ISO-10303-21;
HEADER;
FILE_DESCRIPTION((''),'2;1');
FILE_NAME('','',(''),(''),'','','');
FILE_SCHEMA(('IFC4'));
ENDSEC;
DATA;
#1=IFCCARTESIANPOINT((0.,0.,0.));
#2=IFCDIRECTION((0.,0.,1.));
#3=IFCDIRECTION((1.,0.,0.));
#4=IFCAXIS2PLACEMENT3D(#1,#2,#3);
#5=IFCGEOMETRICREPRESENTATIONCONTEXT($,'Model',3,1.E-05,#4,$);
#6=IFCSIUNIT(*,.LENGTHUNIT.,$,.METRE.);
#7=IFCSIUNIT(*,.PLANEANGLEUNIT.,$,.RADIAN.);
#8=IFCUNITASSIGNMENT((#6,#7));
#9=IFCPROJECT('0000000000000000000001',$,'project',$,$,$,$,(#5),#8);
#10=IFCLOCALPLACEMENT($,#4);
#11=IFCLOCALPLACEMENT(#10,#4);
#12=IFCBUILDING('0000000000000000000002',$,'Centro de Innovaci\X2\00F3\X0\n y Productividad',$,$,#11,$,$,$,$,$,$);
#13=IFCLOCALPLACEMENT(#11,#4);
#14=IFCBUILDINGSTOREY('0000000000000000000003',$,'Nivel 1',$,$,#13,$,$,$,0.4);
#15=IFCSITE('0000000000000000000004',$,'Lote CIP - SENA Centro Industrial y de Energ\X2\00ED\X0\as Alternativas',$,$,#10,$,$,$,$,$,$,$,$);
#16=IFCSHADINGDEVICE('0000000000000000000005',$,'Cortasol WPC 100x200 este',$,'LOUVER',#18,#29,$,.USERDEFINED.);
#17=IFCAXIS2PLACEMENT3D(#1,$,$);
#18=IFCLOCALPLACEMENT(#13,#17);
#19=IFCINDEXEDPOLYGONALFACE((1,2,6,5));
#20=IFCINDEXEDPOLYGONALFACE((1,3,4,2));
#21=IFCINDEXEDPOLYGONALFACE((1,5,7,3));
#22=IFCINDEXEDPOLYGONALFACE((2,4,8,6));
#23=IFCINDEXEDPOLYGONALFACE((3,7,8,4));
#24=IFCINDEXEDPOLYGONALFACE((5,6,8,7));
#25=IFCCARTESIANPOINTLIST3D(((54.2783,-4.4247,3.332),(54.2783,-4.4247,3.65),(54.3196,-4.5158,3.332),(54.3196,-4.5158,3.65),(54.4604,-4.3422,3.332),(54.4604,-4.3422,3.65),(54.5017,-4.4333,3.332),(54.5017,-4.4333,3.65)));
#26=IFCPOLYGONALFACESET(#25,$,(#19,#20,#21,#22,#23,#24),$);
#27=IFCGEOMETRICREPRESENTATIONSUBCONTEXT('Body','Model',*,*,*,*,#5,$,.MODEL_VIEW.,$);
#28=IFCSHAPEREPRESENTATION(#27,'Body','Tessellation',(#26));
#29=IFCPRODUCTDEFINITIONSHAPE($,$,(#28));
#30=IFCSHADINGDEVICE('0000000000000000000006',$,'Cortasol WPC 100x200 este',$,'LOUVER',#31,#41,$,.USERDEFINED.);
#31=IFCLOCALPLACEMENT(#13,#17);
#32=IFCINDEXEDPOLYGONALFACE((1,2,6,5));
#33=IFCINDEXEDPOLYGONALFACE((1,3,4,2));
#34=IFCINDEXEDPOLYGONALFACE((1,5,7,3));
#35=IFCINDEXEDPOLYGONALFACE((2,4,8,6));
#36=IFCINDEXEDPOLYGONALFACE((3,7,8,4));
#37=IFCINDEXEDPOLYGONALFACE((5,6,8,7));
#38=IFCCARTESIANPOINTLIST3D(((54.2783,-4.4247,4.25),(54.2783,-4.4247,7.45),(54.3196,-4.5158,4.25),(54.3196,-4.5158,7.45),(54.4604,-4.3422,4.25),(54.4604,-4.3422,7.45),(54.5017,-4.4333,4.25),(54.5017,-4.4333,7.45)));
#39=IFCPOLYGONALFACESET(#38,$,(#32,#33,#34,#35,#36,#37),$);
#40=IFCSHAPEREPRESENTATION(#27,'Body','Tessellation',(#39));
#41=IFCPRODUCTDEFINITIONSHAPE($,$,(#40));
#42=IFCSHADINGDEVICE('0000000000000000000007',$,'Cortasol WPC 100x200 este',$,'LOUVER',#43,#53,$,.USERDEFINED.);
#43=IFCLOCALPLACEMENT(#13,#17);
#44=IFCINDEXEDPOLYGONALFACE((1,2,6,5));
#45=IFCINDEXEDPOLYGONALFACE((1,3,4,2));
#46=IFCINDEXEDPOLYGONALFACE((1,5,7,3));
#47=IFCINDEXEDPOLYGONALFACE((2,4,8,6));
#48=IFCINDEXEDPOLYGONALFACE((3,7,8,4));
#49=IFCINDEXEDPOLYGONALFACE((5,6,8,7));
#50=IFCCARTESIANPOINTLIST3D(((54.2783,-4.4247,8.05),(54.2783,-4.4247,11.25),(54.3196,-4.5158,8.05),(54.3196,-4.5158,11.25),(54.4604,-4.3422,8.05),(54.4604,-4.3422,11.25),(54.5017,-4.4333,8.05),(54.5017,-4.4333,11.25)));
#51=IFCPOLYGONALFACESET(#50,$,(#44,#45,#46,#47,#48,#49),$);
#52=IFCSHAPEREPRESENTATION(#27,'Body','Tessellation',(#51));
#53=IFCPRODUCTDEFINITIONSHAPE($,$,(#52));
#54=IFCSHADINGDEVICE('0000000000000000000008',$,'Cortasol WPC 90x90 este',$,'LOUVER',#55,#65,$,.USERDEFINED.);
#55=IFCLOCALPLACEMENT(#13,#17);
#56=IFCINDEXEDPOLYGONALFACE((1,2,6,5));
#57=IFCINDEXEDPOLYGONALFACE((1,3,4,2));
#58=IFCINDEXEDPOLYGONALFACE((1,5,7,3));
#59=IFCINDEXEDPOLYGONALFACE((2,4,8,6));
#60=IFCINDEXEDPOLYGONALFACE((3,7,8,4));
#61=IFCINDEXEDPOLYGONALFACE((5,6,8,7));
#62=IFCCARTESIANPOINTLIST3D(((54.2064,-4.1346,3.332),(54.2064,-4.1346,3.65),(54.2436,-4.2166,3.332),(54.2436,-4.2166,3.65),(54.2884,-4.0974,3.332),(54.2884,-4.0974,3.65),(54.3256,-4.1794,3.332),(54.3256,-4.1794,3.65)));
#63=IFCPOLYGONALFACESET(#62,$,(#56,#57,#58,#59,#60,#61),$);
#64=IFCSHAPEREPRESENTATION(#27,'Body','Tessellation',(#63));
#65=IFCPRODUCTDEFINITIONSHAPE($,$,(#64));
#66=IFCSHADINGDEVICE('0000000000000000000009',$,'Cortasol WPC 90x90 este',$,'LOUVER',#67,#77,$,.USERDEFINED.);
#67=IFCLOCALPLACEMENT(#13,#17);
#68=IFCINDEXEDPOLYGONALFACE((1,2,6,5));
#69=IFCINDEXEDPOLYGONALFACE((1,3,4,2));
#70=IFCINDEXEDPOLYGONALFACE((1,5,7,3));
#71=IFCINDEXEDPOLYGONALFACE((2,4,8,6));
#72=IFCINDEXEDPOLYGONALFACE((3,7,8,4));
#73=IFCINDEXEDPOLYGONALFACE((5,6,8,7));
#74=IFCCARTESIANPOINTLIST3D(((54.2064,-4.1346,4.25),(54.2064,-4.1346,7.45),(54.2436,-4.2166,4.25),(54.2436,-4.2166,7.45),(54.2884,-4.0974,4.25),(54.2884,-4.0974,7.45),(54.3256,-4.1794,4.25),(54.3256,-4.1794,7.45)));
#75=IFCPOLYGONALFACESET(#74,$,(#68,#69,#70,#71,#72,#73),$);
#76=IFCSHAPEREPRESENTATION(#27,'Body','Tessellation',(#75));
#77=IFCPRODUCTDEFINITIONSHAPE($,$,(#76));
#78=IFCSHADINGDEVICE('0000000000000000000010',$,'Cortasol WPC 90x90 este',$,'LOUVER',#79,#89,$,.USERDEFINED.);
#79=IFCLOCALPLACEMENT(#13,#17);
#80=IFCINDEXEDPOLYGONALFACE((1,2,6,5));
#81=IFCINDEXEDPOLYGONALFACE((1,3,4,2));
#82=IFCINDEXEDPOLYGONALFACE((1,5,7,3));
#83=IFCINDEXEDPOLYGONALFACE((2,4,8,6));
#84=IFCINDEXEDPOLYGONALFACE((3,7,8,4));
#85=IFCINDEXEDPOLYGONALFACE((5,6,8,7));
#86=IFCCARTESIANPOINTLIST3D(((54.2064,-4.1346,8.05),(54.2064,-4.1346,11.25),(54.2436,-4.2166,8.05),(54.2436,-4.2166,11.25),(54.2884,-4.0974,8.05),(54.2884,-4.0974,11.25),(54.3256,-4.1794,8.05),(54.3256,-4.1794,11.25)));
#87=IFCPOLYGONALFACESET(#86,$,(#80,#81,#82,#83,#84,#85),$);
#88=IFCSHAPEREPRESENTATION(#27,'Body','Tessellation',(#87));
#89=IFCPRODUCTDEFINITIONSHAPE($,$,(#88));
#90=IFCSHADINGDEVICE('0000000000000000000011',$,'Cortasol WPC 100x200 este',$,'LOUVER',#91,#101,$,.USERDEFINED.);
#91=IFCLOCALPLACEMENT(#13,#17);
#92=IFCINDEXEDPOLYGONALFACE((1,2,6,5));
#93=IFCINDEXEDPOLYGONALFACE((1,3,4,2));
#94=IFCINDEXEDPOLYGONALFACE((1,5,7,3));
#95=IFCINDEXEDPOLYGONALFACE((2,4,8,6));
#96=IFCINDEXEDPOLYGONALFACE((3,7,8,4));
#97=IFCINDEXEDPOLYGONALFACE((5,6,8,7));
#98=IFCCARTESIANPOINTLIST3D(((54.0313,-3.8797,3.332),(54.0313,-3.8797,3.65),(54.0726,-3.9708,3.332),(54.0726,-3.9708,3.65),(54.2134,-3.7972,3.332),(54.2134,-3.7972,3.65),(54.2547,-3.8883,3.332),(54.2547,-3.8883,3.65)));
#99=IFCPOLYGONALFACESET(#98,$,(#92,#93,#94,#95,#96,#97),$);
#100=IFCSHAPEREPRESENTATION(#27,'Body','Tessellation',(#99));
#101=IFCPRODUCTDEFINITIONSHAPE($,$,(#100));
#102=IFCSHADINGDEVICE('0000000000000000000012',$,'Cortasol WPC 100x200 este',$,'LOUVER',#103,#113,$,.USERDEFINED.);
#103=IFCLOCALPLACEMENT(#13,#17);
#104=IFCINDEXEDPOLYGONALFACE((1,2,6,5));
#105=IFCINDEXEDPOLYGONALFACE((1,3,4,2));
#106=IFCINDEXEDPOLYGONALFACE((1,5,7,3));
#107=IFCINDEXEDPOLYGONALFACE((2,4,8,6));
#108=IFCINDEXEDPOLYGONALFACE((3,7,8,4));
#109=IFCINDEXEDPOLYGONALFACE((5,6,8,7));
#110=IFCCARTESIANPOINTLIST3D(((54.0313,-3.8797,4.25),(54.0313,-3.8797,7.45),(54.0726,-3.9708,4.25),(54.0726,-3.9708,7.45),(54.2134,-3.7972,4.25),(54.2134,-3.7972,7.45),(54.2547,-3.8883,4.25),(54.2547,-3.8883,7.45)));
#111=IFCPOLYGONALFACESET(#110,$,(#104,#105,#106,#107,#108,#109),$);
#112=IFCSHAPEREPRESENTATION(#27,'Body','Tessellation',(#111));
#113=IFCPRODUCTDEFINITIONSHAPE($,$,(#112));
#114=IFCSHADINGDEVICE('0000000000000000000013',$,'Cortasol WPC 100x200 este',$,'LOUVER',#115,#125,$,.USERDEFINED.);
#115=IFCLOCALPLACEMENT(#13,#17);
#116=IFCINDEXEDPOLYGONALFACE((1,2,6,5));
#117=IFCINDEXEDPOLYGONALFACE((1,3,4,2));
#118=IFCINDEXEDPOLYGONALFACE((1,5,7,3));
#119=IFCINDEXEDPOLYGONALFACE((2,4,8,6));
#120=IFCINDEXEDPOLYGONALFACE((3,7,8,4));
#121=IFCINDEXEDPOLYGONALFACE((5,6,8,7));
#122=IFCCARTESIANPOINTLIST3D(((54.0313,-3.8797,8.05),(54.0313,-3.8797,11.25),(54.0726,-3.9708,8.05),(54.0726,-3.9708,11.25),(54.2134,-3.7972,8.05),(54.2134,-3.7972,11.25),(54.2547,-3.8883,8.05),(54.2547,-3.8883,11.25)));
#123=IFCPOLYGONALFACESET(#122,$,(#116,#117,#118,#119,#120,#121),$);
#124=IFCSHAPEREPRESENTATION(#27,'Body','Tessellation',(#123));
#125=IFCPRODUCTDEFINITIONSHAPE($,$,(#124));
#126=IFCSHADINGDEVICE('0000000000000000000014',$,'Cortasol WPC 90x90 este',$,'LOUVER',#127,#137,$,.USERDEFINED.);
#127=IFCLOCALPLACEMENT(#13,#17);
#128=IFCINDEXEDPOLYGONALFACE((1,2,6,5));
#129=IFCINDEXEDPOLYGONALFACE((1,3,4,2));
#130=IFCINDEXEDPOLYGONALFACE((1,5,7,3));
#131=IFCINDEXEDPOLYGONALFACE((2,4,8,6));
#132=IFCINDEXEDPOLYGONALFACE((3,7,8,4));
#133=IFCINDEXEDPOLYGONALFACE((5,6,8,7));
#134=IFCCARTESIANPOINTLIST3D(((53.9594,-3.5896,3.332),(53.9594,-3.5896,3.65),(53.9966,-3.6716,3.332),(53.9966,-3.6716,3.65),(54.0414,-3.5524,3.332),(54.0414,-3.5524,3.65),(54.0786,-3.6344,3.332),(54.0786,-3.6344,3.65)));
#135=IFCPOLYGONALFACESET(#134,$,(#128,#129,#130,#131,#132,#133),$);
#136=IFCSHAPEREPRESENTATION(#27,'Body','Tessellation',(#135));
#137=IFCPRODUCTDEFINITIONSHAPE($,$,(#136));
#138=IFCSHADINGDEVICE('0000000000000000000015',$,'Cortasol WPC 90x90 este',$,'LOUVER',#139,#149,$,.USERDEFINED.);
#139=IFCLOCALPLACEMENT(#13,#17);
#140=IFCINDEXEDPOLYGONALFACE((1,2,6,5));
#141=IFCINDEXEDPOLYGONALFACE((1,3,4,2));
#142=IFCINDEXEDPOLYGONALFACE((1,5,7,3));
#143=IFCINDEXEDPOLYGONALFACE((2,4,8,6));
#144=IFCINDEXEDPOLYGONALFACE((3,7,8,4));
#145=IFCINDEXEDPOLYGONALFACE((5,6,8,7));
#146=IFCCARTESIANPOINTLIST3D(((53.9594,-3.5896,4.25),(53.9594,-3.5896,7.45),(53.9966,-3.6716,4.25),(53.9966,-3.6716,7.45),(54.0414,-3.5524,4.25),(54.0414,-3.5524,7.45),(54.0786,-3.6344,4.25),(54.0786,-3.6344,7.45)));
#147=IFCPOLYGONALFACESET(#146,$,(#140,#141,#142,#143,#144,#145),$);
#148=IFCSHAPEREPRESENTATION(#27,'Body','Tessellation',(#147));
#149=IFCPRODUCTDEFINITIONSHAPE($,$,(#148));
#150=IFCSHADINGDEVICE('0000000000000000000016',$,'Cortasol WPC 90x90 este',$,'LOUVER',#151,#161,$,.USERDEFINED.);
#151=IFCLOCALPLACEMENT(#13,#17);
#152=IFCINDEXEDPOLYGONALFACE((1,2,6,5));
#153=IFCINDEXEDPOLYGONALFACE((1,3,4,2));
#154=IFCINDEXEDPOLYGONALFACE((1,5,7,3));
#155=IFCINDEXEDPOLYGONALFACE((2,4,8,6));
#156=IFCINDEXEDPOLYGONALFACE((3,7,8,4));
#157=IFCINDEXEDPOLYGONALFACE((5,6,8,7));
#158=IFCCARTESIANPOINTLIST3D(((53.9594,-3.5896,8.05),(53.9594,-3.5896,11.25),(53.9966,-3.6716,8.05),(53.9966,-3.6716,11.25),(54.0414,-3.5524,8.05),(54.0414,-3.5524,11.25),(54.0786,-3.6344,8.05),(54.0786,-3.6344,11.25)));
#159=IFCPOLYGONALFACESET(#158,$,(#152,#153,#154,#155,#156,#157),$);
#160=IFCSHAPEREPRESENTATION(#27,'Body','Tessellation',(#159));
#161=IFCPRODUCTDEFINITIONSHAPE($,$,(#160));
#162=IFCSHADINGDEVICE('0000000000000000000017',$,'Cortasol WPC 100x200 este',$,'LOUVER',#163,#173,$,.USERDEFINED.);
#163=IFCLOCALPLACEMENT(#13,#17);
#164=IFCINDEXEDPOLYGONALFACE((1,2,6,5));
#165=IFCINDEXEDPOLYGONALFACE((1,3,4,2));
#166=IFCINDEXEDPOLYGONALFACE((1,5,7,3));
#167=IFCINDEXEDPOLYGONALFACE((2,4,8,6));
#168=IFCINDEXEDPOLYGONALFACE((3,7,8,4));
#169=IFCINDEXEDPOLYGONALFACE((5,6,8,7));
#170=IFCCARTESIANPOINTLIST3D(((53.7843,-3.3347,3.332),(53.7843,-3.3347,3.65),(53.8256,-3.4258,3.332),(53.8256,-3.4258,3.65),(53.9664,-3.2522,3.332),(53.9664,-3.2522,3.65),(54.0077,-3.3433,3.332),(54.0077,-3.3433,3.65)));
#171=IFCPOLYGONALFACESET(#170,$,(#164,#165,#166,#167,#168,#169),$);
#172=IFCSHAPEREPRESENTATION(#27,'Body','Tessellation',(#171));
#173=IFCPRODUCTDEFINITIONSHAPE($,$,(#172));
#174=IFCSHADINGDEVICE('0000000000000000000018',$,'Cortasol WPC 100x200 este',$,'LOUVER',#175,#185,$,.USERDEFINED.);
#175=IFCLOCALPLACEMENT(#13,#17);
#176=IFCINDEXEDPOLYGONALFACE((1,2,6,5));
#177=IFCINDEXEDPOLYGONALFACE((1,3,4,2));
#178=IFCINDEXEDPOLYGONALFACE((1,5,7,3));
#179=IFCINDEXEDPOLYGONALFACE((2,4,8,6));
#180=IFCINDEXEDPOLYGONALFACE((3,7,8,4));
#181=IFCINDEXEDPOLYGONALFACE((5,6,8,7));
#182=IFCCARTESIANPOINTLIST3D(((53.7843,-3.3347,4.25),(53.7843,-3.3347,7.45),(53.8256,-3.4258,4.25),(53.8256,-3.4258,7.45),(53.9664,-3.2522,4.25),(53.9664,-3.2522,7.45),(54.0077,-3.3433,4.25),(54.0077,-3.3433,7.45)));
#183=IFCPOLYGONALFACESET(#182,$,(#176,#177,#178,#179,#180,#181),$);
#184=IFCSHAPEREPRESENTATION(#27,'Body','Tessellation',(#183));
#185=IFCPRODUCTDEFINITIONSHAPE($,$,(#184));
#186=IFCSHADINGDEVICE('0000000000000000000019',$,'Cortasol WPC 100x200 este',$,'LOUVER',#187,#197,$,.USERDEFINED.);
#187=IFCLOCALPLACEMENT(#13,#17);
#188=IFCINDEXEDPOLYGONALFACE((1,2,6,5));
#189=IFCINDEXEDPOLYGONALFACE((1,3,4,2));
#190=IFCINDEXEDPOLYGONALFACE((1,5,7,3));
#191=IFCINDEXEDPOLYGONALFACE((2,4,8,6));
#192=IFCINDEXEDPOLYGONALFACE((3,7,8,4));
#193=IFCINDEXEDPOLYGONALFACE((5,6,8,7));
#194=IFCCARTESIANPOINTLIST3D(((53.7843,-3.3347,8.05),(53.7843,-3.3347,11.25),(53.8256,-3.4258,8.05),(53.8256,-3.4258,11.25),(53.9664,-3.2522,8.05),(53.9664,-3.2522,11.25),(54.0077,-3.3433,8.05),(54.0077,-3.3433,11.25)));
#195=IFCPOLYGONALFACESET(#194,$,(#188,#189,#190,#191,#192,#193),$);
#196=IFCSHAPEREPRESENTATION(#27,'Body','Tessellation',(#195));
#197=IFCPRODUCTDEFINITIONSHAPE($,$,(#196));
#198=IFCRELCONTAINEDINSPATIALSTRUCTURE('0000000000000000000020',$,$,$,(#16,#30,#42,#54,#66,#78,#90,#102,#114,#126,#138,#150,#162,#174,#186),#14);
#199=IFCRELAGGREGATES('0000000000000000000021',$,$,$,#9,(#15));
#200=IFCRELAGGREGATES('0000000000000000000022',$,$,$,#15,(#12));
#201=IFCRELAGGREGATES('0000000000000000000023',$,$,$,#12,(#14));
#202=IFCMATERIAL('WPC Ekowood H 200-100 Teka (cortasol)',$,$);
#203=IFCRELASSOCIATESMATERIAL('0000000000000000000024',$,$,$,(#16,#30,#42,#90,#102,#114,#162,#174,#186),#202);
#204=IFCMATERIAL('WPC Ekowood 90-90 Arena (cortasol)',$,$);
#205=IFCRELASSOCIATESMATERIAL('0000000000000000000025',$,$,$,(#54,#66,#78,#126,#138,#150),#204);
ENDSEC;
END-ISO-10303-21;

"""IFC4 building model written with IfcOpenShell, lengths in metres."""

from ifc_helpers import new_model, si_unit, frame, origin_with_axes, place, context, subcontext, project, spatial, polyline, outline, extrude, material, element, save


model = new_model("IFC4")

# Units and contexts
model_context = context("Model", 3, precision=1e-05, world=origin_with_axes())
body_context = subcontext(model_context, "Body", "Model", "MODEL_VIEW")
ifc_project = project(units=[si_unit("LENGTHUNIT", "METRE"), si_unit("PLANEANGLEUNIT", "RADIAN")], contexts=[model_context])

# Site, building, storey
site_placement = place(None, origin_with_axes())
site = spatial("IfcSite", under=ifc_project, at=site_placement, Name="Lote CIP - SENA Centro Industrial y de Energías Alternativas")
building_placement = place(site_placement, origin_with_axes())
building = spatial("IfcBuilding", under=site, at=building_placement, Name="Centro de Innovación y Productividad")
storey_placement = place(building_placement, origin_with_axes())
storey = spatial("IfcBuildingStorey", under=building, at=storey_placement, Name="Nivel 1", Elevation=0.4)

# Shading devices
ifc_material_1 = material(Name="WPC Ekowood H 200-100 Teka (cortasol)")
shading_device_1_placement = place(storey_placement, origin_with_axes())
element("IfcShadingDevice", 1, at=shading_device_1_placement, inside=storey, material=ifc_material_1, Name="Cortasol WPC 100x200 este", ObjectType="LOUVER", PredefinedType="USERDEFINED", context=body_context, shape_type="SweptSolid", body=[
    extrude(outline(polyline([(54.2783, -4.4247), (54.4604, -4.3422), (54.5017, -4.4333), (54.3196, -4.5158), (54.2783, -4.4247)])), frame((0.0, 0.0, 3.332)), (0.0, 0.0, 1.0), 0.318),
])
shading_device_2_placement = place(storey_placement, origin_with_axes())
element("IfcShadingDevice", 2, at=shading_device_2_placement, inside=storey, material=ifc_material_1, Name="Cortasol WPC 100x200 este", ObjectType="LOUVER", PredefinedType="USERDEFINED", context=body_context, shape_type="SweptSolid", body=[
    extrude(outline(polyline([(54.2783, -4.4247), (54.4604, -4.3422), (54.5017, -4.4333), (54.3196, -4.5158), (54.2783, -4.4247)])), frame((0.0, 0.0, 4.25)), (0.0, 0.0, 1.0), 3.2),
])
shading_device_3_placement = place(storey_placement, origin_with_axes())
element("IfcShadingDevice", 3, at=shading_device_3_placement, inside=storey, material=ifc_material_1, Name="Cortasol WPC 100x200 este", ObjectType="LOUVER", PredefinedType="USERDEFINED", context=body_context, shape_type="SweptSolid", body=[
    extrude(outline(polyline([(54.2783, -4.4247), (54.4604, -4.3422), (54.5017, -4.4333), (54.3196, -4.5158), (54.2783, -4.4247)])), frame((0.0, 0.0, 8.05)), (0.0, 0.0, 1.0), 3.2),
])
ifc_material_2 = material(Name="WPC Ekowood 90-90 Arena (cortasol)")
shading_device_4_placement = place(storey_placement, origin_with_axes())
element("IfcShadingDevice", 4, at=shading_device_4_placement, inside=storey, material=ifc_material_2, Name="Cortasol WPC 90x90 este", ObjectType="LOUVER", PredefinedType="USERDEFINED", context=body_context, shape_type="SweptSolid", body=[
    extrude(outline(polyline([(54.2064, -4.1346), (54.2884, -4.0974), (54.3256, -4.1794), (54.2436, -4.2166), (54.2064, -4.1346)])), frame((0.0, 0.0, 3.332)), (0.0, 0.0, 1.0), 0.318),
])
shading_device_5_placement = place(storey_placement, origin_with_axes())
element("IfcShadingDevice", 5, at=shading_device_5_placement, inside=storey, material=ifc_material_2, Name="Cortasol WPC 90x90 este", ObjectType="LOUVER", PredefinedType="USERDEFINED", context=body_context, shape_type="SweptSolid", body=[
    extrude(outline(polyline([(54.2064, -4.1346), (54.2884, -4.0974), (54.3256, -4.1794), (54.2436, -4.2166), (54.2064, -4.1346)])), frame((0.0, 0.0, 4.25)), (0.0, 0.0, 1.0), 3.2),
])
shading_device_6_placement = place(storey_placement, origin_with_axes())
element("IfcShadingDevice", 6, at=shading_device_6_placement, inside=storey, material=ifc_material_2, Name="Cortasol WPC 90x90 este", ObjectType="LOUVER", PredefinedType="USERDEFINED", context=body_context, shape_type="SweptSolid", body=[
    extrude(outline(polyline([(54.2064, -4.1346), (54.2884, -4.0974), (54.3256, -4.1794), (54.2436, -4.2166), (54.2064, -4.1346)])), frame((0.0, 0.0, 8.05)), (0.0, 0.0, 1.0), 3.2),
])
shading_device_7_placement = place(storey_placement, origin_with_axes())
element("IfcShadingDevice", 7, at=shading_device_7_placement, inside=storey, material=ifc_material_1, Name="Cortasol WPC 100x200 este", ObjectType="LOUVER", PredefinedType="USERDEFINED", context=body_context, shape_type="SweptSolid", body=[
    extrude(outline(polyline([(54.0313, -3.8797), (54.2134, -3.7972), (54.2547, -3.8883), (54.0726, -3.9708), (54.0313, -3.8797)])), frame((0.0, 0.0, 3.332)), (0.0, 0.0, 1.0), 0.318),
])
shading_device_8_placement = place(storey_placement, origin_with_axes())
element("IfcShadingDevice", 8, at=shading_device_8_placement, inside=storey, material=ifc_material_1, Name="Cortasol WPC 100x200 este", ObjectType="LOUVER", PredefinedType="USERDEFINED", context=body_context, shape_type="SweptSolid", body=[
    extrude(outline(polyline([(54.0313, -3.8797), (54.2134, -3.7972), (54.2547, -3.8883), (54.0726, -3.9708), (54.0313, -3.8797)])), frame((0.0, 0.0, 4.25)), (0.0, 0.0, 1.0), 3.2),
])
shading_device_9_placement = place(storey_placement, origin_with_axes())
element("IfcShadingDevice", 9, at=shading_device_9_placement, inside=storey, material=ifc_material_1, Name="Cortasol WPC 100x200 este", ObjectType="LOUVER", PredefinedType="USERDEFINED", context=body_context, shape_type="SweptSolid", body=[
    extrude(outline(polyline([(54.0313, -3.8797), (54.2134, -3.7972), (54.2547, -3.8883), (54.0726, -3.9708), (54.0313, -3.8797)])), frame((0.0, 0.0, 8.05)), (0.0, 0.0, 1.0), 3.2),
])
shading_device_10_placement = place(storey_placement, origin_with_axes())
element("IfcShadingDevice", 10, at=shading_device_10_placement, inside=storey, material=ifc_material_2, Name="Cortasol WPC 90x90 este", ObjectType="LOUVER", PredefinedType="USERDEFINED", context=body_context, shape_type="SweptSolid", body=[
    extrude(outline(polyline([(53.9594, -3.5896), (54.0414, -3.5524), (54.0786, -3.6344), (53.9966, -3.6716), (53.9594, -3.5896)])), frame((0.0, 0.0, 3.332)), (0.0, 0.0, 1.0), 0.318),
])
shading_device_11_placement = place(storey_placement, origin_with_axes())
element("IfcShadingDevice", 11, at=shading_device_11_placement, inside=storey, material=ifc_material_2, Name="Cortasol WPC 90x90 este", ObjectType="LOUVER", PredefinedType="USERDEFINED", context=body_context, shape_type="SweptSolid", body=[
    extrude(outline(polyline([(53.9594, -3.5896), (54.0414, -3.5524), (54.0786, -3.6344), (53.9966, -3.6716), (53.9594, -3.5896)])), frame((0.0, 0.0, 4.25)), (0.0, 0.0, 1.0), 3.2),
])
shading_device_12_placement = place(storey_placement, origin_with_axes())
element("IfcShadingDevice", 12, at=shading_device_12_placement, inside=storey, material=ifc_material_2, Name="Cortasol WPC 90x90 este", ObjectType="LOUVER", PredefinedType="USERDEFINED", context=body_context, shape_type="SweptSolid", body=[
    extrude(outline(polyline([(53.9594, -3.5896), (54.0414, -3.5524), (54.0786, -3.6344), (53.9966, -3.6716), (53.9594, -3.5896)])), frame((0.0, 0.0, 8.05)), (0.0, 0.0, 1.0), 3.2),
])
shading_device_13_placement = place(storey_placement, origin_with_axes())
element("IfcShadingDevice", 13, at=shading_device_13_placement, inside=storey, material=ifc_material_1, Name="Cortasol WPC 100x200 este", ObjectType="LOUVER", PredefinedType="USERDEFINED", context=body_context, shape_type="SweptSolid", body=[
    extrude(outline(polyline([(53.7843, -3.3347), (53.9664, -3.2522), (54.0077, -3.3433), (53.8256, -3.4258), (53.7843, -3.3347)])), frame((0.0, 0.0, 3.332)), (0.0, 0.0, 1.0), 0.318),
])
shading_device_14_placement = place(storey_placement, origin_with_axes())
element("IfcShadingDevice", 14, at=shading_device_14_placement, inside=storey, material=ifc_material_1, Name="Cortasol WPC 100x200 este", ObjectType="LOUVER", PredefinedType="USERDEFINED", context=body_context, shape_type="SweptSolid", body=[
    extrude(outline(polyline([(53.7843, -3.3347), (53.9664, -3.2522), (54.0077, -3.3433), (53.8256, -3.4258), (53.7843, -3.3347)])), frame((0.0, 0.0, 4.25)), (0.0, 0.0, 1.0), 3.2),
])
shading_device_15_placement = place(storey_placement, origin_with_axes())
element("IfcShadingDevice", 15, at=shading_device_15_placement, inside=storey, material=ifc_material_1, Name="Cortasol WPC 100x200 este", ObjectType="LOUVER", PredefinedType="USERDEFINED", context=body_context, shape_type="SweptSolid", body=[
    extrude(outline(polyline([(53.7843, -3.3347), (53.9664, -3.2522), (54.0077, -3.3433), (53.8256, -3.4258), (53.7843, -3.3347)])), frame((0.0, 0.0, 8.05)), (0.0, 0.0, 1.0), 3.2),
])

save(model, "model.ifc")
